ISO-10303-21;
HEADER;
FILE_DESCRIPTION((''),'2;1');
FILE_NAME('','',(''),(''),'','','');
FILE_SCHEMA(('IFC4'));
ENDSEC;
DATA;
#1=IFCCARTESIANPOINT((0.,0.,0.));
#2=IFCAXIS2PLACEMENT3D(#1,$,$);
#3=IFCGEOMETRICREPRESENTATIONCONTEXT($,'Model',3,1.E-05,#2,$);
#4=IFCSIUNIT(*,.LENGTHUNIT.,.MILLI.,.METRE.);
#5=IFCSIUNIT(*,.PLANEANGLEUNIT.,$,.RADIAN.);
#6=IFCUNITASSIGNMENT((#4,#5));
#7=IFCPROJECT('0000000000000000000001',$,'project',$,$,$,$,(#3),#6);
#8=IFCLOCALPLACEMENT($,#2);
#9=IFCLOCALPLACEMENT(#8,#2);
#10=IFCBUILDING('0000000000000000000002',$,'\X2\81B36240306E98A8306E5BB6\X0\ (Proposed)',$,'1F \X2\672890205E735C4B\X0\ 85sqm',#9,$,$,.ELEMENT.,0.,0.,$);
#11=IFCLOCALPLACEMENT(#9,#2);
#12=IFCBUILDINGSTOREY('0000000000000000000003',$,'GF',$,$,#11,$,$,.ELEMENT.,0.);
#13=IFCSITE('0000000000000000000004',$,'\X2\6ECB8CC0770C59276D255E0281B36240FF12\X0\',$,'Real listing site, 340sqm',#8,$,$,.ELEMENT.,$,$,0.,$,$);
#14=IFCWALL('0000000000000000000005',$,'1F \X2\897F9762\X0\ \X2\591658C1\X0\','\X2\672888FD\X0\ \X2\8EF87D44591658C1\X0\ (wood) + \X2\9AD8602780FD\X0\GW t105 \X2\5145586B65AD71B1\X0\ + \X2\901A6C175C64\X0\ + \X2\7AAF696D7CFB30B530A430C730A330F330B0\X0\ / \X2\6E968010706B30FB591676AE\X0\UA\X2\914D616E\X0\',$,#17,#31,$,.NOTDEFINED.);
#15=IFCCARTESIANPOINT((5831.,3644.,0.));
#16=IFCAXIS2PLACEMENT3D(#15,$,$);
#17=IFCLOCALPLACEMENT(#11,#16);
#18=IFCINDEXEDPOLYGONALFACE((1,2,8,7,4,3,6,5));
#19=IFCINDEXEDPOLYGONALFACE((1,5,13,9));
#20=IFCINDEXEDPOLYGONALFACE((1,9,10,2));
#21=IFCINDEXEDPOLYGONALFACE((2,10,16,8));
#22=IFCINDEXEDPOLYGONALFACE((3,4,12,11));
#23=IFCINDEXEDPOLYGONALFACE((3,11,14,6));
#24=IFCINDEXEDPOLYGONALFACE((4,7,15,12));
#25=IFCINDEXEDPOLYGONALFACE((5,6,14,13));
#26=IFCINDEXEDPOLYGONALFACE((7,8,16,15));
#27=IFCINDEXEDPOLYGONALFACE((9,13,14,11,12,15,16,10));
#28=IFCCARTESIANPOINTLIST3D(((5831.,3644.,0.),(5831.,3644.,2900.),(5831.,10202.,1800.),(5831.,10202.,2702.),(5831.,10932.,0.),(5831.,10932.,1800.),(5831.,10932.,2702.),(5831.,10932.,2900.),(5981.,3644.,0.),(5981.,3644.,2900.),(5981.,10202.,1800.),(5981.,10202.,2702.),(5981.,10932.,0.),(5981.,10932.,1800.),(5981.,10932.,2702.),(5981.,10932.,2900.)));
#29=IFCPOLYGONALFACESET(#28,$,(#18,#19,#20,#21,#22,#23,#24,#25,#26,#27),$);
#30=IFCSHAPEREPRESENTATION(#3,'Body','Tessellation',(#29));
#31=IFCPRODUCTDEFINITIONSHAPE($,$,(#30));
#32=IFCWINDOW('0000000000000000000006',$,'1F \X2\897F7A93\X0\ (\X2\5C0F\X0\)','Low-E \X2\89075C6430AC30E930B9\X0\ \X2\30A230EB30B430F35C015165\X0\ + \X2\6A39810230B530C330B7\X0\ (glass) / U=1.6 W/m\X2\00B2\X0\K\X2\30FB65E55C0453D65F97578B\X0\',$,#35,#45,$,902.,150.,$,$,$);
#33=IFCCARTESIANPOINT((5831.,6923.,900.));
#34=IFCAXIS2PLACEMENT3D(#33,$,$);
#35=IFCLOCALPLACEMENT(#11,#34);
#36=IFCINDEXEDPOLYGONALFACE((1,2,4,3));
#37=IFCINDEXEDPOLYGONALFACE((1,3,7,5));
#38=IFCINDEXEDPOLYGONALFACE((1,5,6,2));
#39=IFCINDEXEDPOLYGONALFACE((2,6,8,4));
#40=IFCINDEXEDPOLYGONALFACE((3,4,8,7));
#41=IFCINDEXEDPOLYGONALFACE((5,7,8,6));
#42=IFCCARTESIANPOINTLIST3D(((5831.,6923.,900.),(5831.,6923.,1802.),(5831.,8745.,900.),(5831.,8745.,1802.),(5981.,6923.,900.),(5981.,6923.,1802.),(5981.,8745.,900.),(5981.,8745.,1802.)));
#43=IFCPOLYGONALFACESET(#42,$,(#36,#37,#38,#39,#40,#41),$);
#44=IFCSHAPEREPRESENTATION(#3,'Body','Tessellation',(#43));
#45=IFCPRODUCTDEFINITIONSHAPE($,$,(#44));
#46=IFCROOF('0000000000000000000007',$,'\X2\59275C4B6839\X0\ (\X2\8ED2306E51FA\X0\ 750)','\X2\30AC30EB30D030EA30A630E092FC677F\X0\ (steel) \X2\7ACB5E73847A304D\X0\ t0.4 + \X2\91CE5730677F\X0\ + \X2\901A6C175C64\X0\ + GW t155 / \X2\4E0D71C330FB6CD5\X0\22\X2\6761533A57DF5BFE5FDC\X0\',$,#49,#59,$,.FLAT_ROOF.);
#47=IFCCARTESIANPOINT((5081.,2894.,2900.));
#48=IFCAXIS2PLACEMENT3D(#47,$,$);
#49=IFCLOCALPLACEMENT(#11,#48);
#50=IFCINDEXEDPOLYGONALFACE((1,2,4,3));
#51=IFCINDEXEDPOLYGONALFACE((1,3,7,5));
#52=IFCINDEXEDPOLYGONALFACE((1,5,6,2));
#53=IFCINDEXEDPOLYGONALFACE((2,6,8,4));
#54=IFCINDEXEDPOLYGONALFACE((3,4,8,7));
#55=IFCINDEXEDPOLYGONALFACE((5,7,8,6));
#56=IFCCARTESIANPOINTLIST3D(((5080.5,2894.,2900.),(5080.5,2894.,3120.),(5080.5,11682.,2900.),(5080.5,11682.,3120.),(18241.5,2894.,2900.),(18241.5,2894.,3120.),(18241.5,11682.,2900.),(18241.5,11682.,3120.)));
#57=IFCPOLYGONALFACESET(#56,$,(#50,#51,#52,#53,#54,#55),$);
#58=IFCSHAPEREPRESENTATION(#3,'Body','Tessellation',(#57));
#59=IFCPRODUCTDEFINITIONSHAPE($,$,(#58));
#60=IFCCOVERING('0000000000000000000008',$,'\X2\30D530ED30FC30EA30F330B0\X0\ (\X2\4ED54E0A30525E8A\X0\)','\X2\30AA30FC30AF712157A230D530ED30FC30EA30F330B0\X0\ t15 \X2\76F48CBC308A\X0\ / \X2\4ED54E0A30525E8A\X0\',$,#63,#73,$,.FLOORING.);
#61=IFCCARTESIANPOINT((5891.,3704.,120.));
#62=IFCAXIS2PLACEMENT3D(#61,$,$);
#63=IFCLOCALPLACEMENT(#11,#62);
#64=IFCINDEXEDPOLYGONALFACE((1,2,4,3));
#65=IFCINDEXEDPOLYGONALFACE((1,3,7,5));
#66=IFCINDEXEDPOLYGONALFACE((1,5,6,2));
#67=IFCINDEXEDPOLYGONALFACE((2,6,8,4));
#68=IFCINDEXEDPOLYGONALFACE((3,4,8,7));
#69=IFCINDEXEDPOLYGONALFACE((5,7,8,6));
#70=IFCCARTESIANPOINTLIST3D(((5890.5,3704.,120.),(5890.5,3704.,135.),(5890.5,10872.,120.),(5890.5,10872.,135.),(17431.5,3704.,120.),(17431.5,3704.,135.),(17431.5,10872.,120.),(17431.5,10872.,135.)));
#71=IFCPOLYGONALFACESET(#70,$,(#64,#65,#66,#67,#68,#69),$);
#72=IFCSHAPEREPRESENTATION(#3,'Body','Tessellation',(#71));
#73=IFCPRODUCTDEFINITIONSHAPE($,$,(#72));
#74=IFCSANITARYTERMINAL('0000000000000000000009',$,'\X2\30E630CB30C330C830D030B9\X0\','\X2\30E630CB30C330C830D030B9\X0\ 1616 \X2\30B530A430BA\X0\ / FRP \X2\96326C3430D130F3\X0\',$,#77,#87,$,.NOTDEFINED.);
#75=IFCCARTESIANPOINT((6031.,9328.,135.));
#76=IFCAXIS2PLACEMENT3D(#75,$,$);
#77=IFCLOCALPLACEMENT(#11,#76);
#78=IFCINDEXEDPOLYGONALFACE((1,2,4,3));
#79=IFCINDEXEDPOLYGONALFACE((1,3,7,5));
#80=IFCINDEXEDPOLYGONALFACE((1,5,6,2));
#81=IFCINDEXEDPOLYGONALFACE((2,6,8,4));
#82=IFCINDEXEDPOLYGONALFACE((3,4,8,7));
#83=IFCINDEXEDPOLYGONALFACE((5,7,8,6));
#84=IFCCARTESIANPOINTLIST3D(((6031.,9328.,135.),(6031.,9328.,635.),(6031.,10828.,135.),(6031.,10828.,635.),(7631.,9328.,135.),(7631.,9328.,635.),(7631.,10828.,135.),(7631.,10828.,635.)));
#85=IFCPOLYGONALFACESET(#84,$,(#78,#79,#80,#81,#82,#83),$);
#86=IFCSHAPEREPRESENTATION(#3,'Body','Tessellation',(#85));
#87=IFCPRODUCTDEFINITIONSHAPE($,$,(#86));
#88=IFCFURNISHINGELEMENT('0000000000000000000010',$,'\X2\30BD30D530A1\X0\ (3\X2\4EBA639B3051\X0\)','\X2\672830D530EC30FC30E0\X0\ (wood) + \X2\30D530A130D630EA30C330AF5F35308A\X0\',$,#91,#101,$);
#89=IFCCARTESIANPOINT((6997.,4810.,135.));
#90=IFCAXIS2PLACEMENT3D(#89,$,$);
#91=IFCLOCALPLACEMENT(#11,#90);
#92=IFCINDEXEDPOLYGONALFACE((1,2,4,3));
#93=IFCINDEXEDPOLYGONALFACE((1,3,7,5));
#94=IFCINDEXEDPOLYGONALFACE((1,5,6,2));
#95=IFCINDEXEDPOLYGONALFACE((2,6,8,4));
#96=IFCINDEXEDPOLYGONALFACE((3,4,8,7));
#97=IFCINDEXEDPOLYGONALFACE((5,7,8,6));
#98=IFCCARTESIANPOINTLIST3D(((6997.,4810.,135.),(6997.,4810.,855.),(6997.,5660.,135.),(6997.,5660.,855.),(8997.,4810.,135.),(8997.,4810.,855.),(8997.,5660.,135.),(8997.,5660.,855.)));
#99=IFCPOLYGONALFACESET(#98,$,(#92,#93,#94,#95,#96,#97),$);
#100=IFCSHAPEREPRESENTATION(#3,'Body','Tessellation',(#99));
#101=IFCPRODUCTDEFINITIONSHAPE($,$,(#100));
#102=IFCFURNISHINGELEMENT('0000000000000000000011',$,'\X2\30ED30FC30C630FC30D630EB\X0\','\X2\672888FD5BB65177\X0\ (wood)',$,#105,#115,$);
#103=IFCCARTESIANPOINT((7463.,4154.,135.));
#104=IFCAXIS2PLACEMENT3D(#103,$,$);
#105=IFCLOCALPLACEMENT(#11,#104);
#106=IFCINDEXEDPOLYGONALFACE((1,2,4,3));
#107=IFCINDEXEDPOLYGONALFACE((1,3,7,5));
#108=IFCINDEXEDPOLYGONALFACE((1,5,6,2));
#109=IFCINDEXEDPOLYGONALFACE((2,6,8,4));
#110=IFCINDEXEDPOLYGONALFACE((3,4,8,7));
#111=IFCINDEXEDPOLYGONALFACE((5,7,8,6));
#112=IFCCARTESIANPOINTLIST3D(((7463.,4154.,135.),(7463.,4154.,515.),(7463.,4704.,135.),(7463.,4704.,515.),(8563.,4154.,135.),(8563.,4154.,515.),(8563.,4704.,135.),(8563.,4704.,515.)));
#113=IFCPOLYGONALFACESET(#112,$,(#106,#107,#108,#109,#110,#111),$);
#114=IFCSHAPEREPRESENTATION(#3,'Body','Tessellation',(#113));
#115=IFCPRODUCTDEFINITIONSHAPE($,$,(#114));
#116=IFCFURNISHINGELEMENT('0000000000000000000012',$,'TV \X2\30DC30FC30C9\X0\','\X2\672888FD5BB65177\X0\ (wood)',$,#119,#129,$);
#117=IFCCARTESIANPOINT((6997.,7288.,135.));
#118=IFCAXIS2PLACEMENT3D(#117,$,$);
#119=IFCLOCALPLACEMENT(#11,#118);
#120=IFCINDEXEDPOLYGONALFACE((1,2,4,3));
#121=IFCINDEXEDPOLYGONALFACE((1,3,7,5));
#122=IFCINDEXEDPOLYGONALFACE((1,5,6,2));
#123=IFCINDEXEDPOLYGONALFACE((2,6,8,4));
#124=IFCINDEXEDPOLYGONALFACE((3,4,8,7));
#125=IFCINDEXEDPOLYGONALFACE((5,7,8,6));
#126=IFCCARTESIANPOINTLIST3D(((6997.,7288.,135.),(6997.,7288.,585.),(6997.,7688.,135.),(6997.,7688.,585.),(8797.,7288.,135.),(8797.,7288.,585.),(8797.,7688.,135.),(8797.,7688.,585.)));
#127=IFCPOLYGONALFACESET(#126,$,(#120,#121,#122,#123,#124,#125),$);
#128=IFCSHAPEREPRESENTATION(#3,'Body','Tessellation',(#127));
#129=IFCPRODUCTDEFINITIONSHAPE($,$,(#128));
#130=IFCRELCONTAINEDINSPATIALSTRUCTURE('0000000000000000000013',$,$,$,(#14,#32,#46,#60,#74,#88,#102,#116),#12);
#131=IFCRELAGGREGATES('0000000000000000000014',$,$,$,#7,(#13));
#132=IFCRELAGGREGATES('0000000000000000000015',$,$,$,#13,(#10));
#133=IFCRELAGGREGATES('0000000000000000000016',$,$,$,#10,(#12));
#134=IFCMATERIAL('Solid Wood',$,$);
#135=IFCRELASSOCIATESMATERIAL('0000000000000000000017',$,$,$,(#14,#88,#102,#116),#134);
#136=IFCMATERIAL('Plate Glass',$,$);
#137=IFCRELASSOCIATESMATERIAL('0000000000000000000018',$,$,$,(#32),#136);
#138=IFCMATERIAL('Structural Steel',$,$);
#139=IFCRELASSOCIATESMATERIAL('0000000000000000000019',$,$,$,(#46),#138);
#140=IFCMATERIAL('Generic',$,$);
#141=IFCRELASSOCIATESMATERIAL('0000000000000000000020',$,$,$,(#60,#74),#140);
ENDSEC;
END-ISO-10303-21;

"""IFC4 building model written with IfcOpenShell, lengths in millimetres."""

from ifc_helpers import new_model, si_unit, frame, frame_2d, origin, place, context, project, spatial, rectangle, extrude, material, element, fill, save


model = new_model("IFC4")

# Units and contexts
model_context = context("Model", 3, precision=1e-05, world=origin())
ifc_project = project(units=[si_unit("LENGTHUNIT", "METRE", prefix="MILLI"), si_unit("PLANEANGLEUNIT", "RADIAN")], contexts=[model_context])

# Site, building, storey
site_placement = place(None, origin())
site = spatial("IfcSite", under=ifc_project, at=site_placement, Name="滋賀県大津市膳所２", ObjectType="Real listing site, 340sqm", CompositionType="ELEMENT", RefElevation=0.0)
building_placement = place(site_placement, origin())
building = spatial("IfcBuilding", under=site, at=building_placement, Name="膳所の風の家 (Proposed)", ObjectType="1F 木造平屋 85sqm", CompositionType="ELEMENT", ElevationOfRefHeight=0.0, ElevationOfTerrain=0.0)
storey_placement = place(building_placement, origin())
storey = spatial("IfcBuildingStorey", under=building, at=storey_placement, Name="GF", CompositionType="ELEMENT", Elevation=0.0)

# Shared definitions
ifc_material_1 = material(Name="Solid Wood")

# Shared definitions
ifc_material_2 = material(Name="Plate Glass")

# Wall, opening, window
wall_1_placement = place(storey_placement, frame((5831.0, 3644.0, 0.0)))
wall_1 = element("IfcWall", 1, at=wall_1_placement, inside=storey, material=ifc_material_1, Name="1F 西面 外壁", Description="木製 軸組外壁 (wood) + 高性能GW t105 充填断熱 + 通気層 + 窯業系サイディング / 準耐火・外皮UA配慮", PredefinedType="NOTDEFINED", context=model_context, shape_type="SweptSolid", body=[
    extrude(rectangle(XDim=150.0, YDim=7288.0, at=frame_2d((75.0, 3644.0))), frame((5831.0, 3644.0, 0.0)), (0.0, 0.0, 1.0), 2900.0),
])
opening_1_placement = place(storey_placement, frame((5831.0, 6923.0, 900.0)))
opening_1 = element("IfcOpeningElement", 2, at=opening_1_placement, cuts=wall_1, PredefinedType="NOTDEFINED", context=model_context, shape_type="SweptSolid", body=[
    extrude(rectangle(XDim=150.0, YDim=1822.0, at=frame_2d((75.0, 911.0))), frame((5831.0, 6923.0, 900.0)), (0.0, 0.0, 1.0), 902.0),
])
window_1_placement = place(storey_placement, frame((5831.0, 6923.0, 900.0)))
window_1 = element("IfcWindow", 3, at=window_1_placement, inside=storey, material=ifc_material_2, Name="1F 西窓 (小)", Description="Low-E 複層ガラス アルゴン封入 + 樹脂サッシ (glass) / U=1.6 W/m²K・日射取得型", OverallHeight=902.0, OverallWidth=150.0, context=model_context, shape_type="SweptSolid", body=[
    extrude(rectangle(XDim=150.0, YDim=1822.0, at=frame_2d((75.0, 911.0))), frame((5831.0, 6923.0, 900.0)), (0.0, 0.0, 1.0), 902.0),
])
fill(opening_1, window_1)

# Roof
ifc_material_3 = material(Name="Structural Steel")
roof_placement = place(storey_placement, frame((5081.0, 2894.0, 2900.0)))
element("IfcRoof", 4, at=roof_placement, inside=storey, material=ifc_material_3, Name="大屋根 (軒の出 750)", Description="ガルバリウム鋼板 (steel) 立平葺き t0.4 + 野地板 + 通気層 + GW t155 / 不燃・法22条区域対応", PredefinedType="FLAT_ROOF", context=model_context, shape_type="SweptSolid", body=[
    extrude(rectangle(XDim=13161.0, YDim=8788.0, at=frame_2d((6580.0, 4394.0))), frame((5081.0, 2894.0, 2900.0)), (0.0, 0.0, 1.0), 220.0),
])

# Covering
ifc_material_4 = material(Name="Generic")
covering_placement = place(storey_placement, frame((5891.0, 3704.0, 120.0)))
element("IfcCovering", 5, at=covering_placement, inside=storey, material=ifc_material_4, Name="フローリング (仕上げ床)", Description="オーク無垢フローリング t15 直貼り / 仕上げ床", PredefinedType="FLOORING", context=model_context, shape_type="SweptSolid", body=[
    extrude(rectangle(XDim=11541.0, YDim=7168.0, at=frame_2d((5770.0, 3584.0))), frame((5891.0, 3704.0, 120.0)), (0.0, 0.0, 1.0), 15.0),
])

# Sanitary terminal
sanitary_terminal_placement = place(storey_placement, frame((6031.0, 9328.0, 135.0)))
element("IfcSanitaryTerminal", 6, at=sanitary_terminal_placement, inside=storey, material=ifc_material_4, Name="ユニットバス", Description="ユニットバス 1616 サイズ / FRP 防水パン", PredefinedType="NOTDEFINED", context=model_context, shape_type="SweptSolid", body=[
    extrude(rectangle(XDim=1600.0, YDim=1500.0, at=frame_2d((800.0, 750.0))), frame((6031.0, 9328.0, 135.0)), (0.0, 0.0, 1.0), 500.0),
])

# Furnishing elements
furnishing_1_placement = place(storey_placement, frame((6997.0, 4810.0, 135.0)))
element("IfcFurnishingElement", 7, at=furnishing_1_placement, inside=storey, material=ifc_material_1, Name="ソファ (3人掛け)", Description="木フレーム (wood) + ファブリック張り", context=model_context, shape_type="SweptSolid", body=[
    extrude(rectangle(XDim=2000.0, YDim=850.0, at=frame_2d((1000.0, 425.0))), frame((6997.0, 4810.0, 135.0)), (0.0, 0.0, 1.0), 720.0),
])
furnishing_2_placement = place(storey_placement, frame((7463.0, 4154.0, 135.0)))
element("IfcFurnishingElement", 8, at=furnishing_2_placement, inside=storey, material=ifc_material_1, Name="ローテーブル", Description="木製家具 (wood)", context=model_context, shape_type="SweptSolid", body=[
    extrude(rectangle(XDim=1100.0, YDim=550.0, at=frame_2d((550.0, 275.0))), frame((7463.0, 4154.0, 135.0)), (0.0, 0.0, 1.0), 380.0),
])
furnishing_3_placement = place(storey_placement, frame((6997.0, 7288.0, 135.0)))
element("IfcFurnishingElement", 9, at=furnishing_3_placement, inside=storey, material=ifc_material_1, Name="TV ボード", Description="木製家具 (wood)", context=model_context, shape_type="SweptSolid", body=[
    extrude(rectangle(XDim=1800.0, YDim=400.0, at=frame_2d((900.0, 200.0))), frame((6997.0, 7288.0, 135.0)), (0.0, 0.0, 1.0), 450.0),
])

save(model, "model.ifc")
